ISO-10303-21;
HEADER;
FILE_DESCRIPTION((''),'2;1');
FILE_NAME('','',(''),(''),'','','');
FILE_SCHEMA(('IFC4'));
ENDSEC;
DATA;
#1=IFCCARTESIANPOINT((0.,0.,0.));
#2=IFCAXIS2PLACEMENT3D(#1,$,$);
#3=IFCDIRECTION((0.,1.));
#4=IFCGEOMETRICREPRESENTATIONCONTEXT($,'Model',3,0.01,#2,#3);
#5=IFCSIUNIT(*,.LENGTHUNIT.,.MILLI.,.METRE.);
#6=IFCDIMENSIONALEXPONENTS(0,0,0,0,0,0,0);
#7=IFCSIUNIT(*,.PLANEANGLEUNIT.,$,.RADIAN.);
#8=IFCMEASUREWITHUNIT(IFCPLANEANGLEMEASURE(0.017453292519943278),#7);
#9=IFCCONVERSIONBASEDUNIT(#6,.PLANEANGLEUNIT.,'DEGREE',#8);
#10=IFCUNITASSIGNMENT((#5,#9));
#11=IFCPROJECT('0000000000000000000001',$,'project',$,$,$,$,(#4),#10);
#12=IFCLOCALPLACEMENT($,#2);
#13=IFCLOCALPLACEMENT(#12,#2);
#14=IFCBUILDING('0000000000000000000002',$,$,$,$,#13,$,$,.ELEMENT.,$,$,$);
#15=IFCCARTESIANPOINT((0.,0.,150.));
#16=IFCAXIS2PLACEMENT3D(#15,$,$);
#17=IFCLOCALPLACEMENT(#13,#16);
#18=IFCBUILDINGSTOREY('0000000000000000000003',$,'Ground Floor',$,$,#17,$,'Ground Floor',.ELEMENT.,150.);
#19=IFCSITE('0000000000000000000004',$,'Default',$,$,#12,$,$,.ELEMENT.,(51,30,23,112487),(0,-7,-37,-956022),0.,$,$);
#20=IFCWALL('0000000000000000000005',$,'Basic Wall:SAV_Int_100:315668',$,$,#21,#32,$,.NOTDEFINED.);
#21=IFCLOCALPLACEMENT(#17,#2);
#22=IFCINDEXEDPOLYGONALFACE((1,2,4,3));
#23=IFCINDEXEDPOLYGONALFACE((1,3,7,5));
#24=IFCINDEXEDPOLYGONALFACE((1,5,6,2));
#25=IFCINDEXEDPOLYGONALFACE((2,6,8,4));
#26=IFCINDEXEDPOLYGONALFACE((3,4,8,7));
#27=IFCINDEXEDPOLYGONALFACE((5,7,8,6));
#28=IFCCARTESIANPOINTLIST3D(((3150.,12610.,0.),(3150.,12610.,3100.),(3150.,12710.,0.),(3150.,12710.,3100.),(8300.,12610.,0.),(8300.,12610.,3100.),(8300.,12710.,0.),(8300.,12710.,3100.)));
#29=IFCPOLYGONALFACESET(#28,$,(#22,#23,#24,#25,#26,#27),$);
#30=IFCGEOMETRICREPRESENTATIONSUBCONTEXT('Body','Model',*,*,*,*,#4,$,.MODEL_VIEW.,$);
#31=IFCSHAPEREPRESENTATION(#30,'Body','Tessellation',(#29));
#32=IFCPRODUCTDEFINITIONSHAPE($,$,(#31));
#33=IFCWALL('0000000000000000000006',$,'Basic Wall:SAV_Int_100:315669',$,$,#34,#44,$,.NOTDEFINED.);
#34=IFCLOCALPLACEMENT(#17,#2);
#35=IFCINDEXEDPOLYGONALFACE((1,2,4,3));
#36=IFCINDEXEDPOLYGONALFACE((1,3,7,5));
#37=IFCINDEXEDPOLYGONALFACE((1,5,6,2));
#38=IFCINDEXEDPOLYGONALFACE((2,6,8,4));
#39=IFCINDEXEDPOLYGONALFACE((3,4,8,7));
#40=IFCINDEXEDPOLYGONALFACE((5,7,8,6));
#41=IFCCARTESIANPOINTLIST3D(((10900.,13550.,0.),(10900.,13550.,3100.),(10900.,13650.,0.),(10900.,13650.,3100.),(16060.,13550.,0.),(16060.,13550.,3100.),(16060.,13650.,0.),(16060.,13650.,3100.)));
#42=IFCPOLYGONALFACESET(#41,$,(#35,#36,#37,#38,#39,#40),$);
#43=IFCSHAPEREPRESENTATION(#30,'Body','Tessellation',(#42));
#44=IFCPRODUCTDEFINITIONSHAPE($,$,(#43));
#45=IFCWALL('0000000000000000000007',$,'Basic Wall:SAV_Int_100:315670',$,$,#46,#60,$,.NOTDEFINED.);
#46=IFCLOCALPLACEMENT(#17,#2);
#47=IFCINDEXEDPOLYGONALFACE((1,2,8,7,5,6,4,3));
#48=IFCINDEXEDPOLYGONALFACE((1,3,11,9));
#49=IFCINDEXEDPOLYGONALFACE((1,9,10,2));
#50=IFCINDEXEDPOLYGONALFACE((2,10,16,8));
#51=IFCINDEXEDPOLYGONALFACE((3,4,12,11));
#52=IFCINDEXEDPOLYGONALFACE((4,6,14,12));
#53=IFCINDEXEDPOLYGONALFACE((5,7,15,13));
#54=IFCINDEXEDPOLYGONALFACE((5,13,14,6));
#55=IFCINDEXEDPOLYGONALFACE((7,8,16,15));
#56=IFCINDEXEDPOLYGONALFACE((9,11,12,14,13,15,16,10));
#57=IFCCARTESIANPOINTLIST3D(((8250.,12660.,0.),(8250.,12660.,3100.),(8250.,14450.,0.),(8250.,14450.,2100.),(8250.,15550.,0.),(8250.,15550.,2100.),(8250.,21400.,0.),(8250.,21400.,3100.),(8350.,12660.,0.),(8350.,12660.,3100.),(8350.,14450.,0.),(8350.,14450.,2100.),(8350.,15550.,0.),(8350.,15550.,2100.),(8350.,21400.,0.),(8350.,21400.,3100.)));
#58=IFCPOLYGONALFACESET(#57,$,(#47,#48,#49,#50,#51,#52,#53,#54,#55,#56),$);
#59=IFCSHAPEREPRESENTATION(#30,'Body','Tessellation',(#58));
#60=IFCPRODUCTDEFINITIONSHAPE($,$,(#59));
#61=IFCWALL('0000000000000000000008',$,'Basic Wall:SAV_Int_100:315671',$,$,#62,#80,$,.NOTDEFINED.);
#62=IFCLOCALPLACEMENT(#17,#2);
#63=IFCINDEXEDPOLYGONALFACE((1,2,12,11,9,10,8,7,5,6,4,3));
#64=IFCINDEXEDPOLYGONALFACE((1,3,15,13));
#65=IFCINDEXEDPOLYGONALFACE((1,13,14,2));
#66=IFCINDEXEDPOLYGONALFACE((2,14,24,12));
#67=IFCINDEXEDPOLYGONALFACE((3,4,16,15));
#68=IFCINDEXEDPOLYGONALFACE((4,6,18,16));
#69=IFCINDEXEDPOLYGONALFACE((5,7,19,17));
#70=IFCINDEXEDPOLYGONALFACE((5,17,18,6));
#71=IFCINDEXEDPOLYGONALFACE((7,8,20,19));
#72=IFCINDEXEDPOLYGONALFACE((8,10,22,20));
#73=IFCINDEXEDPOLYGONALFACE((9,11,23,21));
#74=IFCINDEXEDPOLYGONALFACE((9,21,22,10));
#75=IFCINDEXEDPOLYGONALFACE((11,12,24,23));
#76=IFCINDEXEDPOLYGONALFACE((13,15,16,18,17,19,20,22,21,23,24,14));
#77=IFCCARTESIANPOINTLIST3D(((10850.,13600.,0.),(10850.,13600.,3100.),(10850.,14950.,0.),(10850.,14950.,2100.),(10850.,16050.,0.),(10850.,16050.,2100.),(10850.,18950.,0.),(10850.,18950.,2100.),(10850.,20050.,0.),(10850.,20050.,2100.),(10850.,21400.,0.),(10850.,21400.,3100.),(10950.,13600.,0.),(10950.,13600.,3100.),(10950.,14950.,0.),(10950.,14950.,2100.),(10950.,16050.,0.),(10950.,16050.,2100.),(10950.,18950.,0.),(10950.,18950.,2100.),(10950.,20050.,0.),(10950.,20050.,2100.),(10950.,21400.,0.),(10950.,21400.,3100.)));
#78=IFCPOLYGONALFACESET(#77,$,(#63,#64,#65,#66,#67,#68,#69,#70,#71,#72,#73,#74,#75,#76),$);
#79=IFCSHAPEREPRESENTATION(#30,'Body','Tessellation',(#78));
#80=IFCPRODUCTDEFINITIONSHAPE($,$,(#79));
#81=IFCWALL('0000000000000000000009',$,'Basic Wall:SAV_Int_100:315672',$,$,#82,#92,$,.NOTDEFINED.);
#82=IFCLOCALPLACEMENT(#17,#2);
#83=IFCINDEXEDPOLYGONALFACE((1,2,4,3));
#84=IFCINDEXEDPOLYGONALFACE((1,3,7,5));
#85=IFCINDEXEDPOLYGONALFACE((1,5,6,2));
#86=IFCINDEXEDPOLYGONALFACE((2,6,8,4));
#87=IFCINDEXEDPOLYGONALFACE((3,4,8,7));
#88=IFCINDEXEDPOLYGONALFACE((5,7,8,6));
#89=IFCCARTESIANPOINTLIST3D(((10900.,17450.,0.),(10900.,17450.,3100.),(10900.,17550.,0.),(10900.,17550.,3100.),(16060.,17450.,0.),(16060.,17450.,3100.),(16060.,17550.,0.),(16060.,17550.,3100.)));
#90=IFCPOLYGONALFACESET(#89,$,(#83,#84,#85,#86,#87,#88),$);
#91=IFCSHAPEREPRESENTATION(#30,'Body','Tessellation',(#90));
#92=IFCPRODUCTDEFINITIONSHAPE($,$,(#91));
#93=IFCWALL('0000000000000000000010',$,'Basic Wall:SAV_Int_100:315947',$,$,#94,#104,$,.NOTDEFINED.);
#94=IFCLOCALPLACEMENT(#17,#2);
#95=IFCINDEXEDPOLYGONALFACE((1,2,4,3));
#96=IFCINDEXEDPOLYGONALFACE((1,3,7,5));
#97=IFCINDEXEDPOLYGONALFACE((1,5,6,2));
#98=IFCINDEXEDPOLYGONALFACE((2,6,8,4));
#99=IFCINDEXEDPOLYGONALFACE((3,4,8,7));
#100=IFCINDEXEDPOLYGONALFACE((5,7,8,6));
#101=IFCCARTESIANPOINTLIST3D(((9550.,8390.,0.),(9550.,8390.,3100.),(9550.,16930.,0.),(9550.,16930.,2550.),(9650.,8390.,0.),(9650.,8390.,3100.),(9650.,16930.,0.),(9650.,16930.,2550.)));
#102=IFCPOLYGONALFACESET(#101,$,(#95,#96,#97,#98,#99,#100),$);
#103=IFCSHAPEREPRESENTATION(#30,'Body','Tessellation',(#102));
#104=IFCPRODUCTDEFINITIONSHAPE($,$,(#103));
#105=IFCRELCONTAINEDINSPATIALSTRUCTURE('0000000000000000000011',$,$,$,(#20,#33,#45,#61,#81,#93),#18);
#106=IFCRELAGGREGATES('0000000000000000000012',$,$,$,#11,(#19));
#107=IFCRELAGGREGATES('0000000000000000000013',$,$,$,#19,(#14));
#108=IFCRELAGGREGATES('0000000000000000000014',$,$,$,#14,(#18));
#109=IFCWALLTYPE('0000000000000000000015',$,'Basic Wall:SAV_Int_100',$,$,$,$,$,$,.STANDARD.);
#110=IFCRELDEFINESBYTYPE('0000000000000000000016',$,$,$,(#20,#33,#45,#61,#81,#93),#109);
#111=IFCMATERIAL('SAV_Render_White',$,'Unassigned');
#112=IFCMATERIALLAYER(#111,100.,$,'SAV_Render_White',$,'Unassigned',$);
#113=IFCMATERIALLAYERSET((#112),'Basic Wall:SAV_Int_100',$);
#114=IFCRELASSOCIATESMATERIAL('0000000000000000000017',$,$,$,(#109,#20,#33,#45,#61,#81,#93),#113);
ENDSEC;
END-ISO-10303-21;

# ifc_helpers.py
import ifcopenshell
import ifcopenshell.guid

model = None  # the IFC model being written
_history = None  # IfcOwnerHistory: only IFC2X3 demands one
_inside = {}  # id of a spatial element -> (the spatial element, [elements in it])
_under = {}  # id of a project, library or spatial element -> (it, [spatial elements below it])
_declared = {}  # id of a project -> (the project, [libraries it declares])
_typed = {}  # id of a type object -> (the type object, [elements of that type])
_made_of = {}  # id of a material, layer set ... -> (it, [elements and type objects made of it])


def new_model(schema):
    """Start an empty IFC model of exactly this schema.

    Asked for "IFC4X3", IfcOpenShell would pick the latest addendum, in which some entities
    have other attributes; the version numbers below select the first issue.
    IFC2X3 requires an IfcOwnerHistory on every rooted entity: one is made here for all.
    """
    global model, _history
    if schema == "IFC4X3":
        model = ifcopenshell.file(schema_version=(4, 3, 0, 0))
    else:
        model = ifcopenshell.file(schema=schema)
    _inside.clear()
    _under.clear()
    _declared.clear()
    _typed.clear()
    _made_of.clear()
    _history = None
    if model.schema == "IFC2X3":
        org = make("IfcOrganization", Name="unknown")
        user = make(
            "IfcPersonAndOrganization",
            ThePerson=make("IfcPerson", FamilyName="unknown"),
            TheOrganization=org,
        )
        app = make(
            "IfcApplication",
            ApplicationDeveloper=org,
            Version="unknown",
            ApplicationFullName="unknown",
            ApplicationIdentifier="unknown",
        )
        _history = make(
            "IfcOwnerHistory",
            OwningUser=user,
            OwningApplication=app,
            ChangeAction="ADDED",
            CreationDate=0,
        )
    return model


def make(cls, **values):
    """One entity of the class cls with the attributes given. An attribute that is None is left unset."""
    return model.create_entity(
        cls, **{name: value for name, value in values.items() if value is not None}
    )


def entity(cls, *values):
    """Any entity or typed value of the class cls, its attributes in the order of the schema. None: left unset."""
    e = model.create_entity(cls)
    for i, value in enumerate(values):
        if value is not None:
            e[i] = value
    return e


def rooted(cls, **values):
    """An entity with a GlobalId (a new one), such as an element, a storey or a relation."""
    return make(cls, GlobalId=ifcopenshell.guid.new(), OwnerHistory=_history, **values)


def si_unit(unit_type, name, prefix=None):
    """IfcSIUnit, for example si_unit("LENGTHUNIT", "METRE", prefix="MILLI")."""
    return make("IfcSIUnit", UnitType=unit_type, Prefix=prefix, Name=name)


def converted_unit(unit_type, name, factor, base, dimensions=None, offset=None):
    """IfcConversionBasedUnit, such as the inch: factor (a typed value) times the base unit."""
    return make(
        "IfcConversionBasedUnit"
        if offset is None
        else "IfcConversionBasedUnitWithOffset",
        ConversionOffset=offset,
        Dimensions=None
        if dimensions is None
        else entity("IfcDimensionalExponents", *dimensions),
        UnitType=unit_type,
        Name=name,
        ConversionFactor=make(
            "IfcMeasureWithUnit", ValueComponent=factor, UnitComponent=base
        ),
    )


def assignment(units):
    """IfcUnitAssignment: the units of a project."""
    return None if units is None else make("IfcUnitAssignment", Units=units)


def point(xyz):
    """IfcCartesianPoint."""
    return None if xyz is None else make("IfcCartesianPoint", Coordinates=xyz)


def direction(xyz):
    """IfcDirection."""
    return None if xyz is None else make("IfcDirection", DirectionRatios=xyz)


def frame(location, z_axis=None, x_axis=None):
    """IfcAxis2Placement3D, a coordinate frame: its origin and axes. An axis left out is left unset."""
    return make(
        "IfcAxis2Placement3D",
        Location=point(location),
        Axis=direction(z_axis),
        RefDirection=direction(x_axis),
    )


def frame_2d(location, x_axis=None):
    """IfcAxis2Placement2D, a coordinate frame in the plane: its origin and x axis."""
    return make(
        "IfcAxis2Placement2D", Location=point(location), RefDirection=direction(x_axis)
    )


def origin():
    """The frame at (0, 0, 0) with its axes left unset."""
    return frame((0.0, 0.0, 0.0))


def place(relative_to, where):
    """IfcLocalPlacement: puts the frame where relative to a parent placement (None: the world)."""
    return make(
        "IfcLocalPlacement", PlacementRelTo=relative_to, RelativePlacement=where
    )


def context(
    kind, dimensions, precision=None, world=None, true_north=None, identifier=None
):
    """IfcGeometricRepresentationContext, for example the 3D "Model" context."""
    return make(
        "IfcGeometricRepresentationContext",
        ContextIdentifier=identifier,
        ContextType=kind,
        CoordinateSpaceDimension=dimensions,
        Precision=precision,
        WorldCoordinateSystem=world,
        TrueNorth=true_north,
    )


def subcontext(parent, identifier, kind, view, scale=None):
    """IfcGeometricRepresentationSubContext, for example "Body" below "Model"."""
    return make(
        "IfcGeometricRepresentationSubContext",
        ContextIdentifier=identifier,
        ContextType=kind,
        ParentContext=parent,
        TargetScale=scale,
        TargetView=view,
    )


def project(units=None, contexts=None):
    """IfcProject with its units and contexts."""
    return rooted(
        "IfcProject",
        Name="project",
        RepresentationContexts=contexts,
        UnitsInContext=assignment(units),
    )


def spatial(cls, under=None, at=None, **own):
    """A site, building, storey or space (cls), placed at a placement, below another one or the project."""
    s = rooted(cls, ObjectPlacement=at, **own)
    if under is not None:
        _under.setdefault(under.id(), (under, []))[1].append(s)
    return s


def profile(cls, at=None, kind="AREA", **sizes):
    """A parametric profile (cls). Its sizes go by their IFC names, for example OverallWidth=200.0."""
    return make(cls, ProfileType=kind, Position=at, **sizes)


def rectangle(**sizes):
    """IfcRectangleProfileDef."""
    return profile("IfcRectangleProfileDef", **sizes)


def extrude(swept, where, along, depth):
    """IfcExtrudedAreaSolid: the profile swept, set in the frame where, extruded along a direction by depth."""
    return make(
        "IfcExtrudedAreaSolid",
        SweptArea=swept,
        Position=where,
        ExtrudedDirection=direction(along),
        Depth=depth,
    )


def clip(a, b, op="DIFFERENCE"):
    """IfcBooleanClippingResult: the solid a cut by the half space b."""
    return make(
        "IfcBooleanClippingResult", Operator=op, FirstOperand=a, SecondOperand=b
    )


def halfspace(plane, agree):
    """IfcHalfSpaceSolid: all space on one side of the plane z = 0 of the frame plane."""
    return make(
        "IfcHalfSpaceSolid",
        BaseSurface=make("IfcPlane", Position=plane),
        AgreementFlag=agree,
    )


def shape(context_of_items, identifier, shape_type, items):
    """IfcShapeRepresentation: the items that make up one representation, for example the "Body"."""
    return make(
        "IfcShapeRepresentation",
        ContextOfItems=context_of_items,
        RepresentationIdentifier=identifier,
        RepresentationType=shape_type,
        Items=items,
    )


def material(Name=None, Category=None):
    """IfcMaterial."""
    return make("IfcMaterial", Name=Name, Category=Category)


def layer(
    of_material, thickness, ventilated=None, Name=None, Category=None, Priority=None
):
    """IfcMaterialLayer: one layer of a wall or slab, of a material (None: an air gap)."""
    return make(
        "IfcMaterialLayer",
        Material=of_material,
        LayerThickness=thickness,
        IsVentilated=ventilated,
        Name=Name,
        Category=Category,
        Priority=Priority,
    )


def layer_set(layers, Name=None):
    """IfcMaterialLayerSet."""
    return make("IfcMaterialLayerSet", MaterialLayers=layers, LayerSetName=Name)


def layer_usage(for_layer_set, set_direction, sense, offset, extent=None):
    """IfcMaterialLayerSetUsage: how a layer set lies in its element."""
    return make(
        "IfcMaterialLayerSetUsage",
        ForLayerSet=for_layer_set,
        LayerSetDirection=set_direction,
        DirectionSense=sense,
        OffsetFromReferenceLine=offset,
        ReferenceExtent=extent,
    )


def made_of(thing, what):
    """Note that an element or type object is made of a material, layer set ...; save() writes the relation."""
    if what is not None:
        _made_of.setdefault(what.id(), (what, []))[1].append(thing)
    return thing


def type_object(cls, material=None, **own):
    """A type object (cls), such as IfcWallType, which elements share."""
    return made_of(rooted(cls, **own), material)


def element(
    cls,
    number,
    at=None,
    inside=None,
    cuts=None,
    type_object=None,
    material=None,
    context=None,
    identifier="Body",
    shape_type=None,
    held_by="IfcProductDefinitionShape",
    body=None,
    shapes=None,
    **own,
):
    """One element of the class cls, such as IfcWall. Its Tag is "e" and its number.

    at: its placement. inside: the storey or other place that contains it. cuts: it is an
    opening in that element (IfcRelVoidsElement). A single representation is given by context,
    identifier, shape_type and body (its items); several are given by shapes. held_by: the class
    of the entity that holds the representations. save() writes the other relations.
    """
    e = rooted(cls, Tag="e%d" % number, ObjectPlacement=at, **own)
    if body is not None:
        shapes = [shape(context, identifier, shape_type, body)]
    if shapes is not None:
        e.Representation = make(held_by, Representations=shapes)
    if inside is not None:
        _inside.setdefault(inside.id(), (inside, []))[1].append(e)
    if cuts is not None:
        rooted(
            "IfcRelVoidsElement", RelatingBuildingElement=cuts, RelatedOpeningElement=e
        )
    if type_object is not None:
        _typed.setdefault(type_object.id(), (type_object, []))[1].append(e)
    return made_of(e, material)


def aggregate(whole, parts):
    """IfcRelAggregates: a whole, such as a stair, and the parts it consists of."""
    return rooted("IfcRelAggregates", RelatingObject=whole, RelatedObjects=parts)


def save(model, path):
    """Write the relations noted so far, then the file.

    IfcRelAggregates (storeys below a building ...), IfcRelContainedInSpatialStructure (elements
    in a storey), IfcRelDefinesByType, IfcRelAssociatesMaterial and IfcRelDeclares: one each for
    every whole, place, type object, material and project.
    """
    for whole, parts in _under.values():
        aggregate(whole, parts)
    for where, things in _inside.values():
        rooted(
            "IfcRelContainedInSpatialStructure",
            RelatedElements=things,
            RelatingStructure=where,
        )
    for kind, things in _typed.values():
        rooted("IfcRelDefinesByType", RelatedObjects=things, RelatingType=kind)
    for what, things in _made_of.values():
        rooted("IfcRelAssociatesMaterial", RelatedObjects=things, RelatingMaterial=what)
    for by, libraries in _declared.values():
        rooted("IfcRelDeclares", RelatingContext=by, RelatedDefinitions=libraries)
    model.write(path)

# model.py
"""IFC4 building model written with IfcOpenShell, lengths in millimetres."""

from ifc_helpers import new_model, entity, si_unit, converted_unit, direction, frame, frame_2d, origin, place, context, subcontext, project, spatial, rectangle, extrude, clip, halfspace, material, layer, layer_set, layer_usage, type_object, element, save


model = new_model("IFC4")

# Units and contexts
model_context = context("Model", 3, precision=0.01, world=origin(), true_north=direction((0.0, 1.0)))
body_context = subcontext(model_context, "Body", "Model", "MODEL_VIEW")
ifc_project = project(units=[si_unit("LENGTHUNIT", "METRE", prefix="MILLI"), converted_unit("PLANEANGLEUNIT", "DEGREE", entity("IfcPlaneAngleMeasure", 0.017453292519943278), si_unit("PLANEANGLEUNIT", "RADIAN"), dimensions=[0, 0, 0, 0, 0, 0, 0])], contexts=[model_context])

# Site, building, storey
site_placement = place(None, origin())
site = spatial("IfcSite", under=ifc_project, at=site_placement, Name="Default", CompositionType="ELEMENT", RefLatitude=(51, 30, 23, 112487), RefLongitude=(0, -7, -37, -956022), RefElevation=0.0)
building_placement = place(site_placement, origin())
building = spatial("IfcBuilding", under=site, at=building_placement, CompositionType="ELEMENT")
storey_placement = place(building_placement, frame((0.0, 0.0, 150.0)))
storey = spatial("IfcBuildingStorey", under=building, at=storey_placement, Name="Ground Floor", LongName="Ground Floor", CompositionType="ELEMENT", Elevation=150.0)

# Walls
ifc_material_1 = material(Name="SAV_Render_White", Category="Unassigned")
ifc_layer = layer(ifc_material_1, 100.0, Name="SAV_Render_White", Category="Unassigned")
ifc_layer_set = layer_set([ifc_layer], Name="Basic Wall:SAV_Int_100")
ifc_layer_usage_1 = layer_usage(ifc_layer_set, "AXIS2", "NEGATIVE", 50.0)
wall_type = type_object("IfcWallType", Name="Basic Wall:SAV_Int_100", PredefinedType="STANDARD", material=ifc_layer_set)
wall_1_placement = place(storey_placement, frame((3150.0, 12660.0, 0.0)))
element("IfcWall", 1, at=wall_1_placement, inside=storey, type_object=wall_type, material=ifc_layer_usage_1, Name="Basic Wall:SAV_Int_100:315668", PredefinedType="NOTDEFINED", context=body_context, shape_type="SweptSolid", body=[
    extrude(rectangle(XDim=5150.0, YDim=100.0, at=frame_2d((2575.0, 0.0), x_axis=(-1.0, 0.0))), origin(), (0.0, 0.0, 1.0), 3100.0),
])
ifc_layer_usage_2 = layer_usage(ifc_layer_set, "AXIS2", "NEGATIVE", 50.0)
wall_2_placement = place(storey_placement, frame((10900.0, 13600.0, 0.0)))
element("IfcWall", 2, at=wall_2_placement, inside=storey, type_object=wall_type, material=ifc_layer_usage_2, Name="Basic Wall:SAV_Int_100:315669", PredefinedType="NOTDEFINED", context=body_context, shape_type="SweptSolid", body=[
    extrude(rectangle(XDim=5160.0, YDim=100.0, at=frame_2d((2580.0, 0.0), x_axis=(-1.0, 0.0))), origin(), (0.0, 0.0, 1.0), 3100.0),
])

# Wall, opening
ifc_layer_usage_3 = layer_usage(ifc_layer_set, "AXIS2", "NEGATIVE", 50.0)
wall_3_placement = place(storey_placement, frame((8300.0, 12660.0, 0.0), z_axis=(0.0, 0.0, 1.0), x_axis=(0.0, 1.0, 0.0)))
wall_3 = element("IfcWall", 3, at=wall_3_placement, inside=storey, type_object=wall_type, material=ifc_layer_usage_3, Name="Basic Wall:SAV_Int_100:315670", PredefinedType="NOTDEFINED", context=body_context, shape_type="SweptSolid", body=[
    extrude(rectangle(XDim=8740.0, YDim=100.0, at=frame_2d((4370.0, 0.0), x_axis=(1.0, 0.0))), origin(), (0.0, 0.0, 1.0), 3100.0),
])
opening_1_placement = place(wall_3_placement, frame((1790.0, -50.0, 0.0)))
element("IfcOpeningElement", 4, at=opening_1_placement, cuts=wall_3, PredefinedType="OPENING", context=body_context, shape_type="SweptSolid", body=[
    extrude(rectangle(XDim=2100.0, YDim=1100.0, at=frame_2d((1050.0, 550.0), x_axis=(1.0, 0.0))), frame((0.0, 0.0, 0.0), z_axis=(0.0, 1.0, 0.0), x_axis=(0.0, 0.0, 1.0)), (0.0, 0.0, 1.0), 100.0),
])

# Wall, openings
ifc_layer_usage_4 = layer_usage(ifc_layer_set, "AXIS2", "NEGATIVE", 50.0)
wall_4_placement = place(storey_placement, frame((10900.0, 13600.0, 0.0), z_axis=(0.0, 0.0, 1.0), x_axis=(0.0, 1.0, 0.0)))
wall_4 = element("IfcWall", 5, at=wall_4_placement, inside=storey, type_object=wall_type, material=ifc_layer_usage_4, Name="Basic Wall:SAV_Int_100:315671", PredefinedType="NOTDEFINED", context=body_context, shape_type="SweptSolid", body=[
    extrude(rectangle(XDim=7800.0, YDim=100.0, at=frame_2d((3900.0, 0.0), x_axis=(1.0, 0.0))), origin(), (0.0, 0.0, 1.0), 3100.0),
])
opening_2_placement = place(wall_4_placement, frame((5350.0, -50.0, 0.0)))
element("IfcOpeningElement", 6, at=opening_2_placement, cuts=wall_4, PredefinedType="OPENING", context=body_context, shape_type="SweptSolid", body=[
    extrude(rectangle(XDim=2100.0, YDim=1100.0, at=frame_2d((1050.0, 550.0), x_axis=(1.0, 0.0))), frame((0.0, 0.0, 0.0), z_axis=(0.0, 1.0, 0.0), x_axis=(0.0, 0.0, 1.0)), (0.0, 0.0, 1.0), 100.0),
])
opening_3_placement = place(wall_4_placement, frame((1350.0, -50.0, 0.0)))
element("IfcOpeningElement", 7, at=opening_3_placement, cuts=wall_4, PredefinedType="OPENING", context=body_context, shape_type="SweptSolid", body=[
    extrude(rectangle(XDim=2100.0, YDim=1100.0, at=frame_2d((1050.0, 550.0), x_axis=(1.0, 0.0))), frame((0.0, 0.0, 0.0), z_axis=(0.0, 1.0, 0.0), x_axis=(0.0, 0.0, 1.0)), (0.0, 0.0, 1.0), 100.0),
])

# Walls
ifc_layer_usage_5 = layer_usage(ifc_layer_set, "AXIS2", "NEGATIVE", 50.0)
wall_5_placement = place(storey_placement, frame((10900.0, 17500.0, 0.0)))
element("IfcWall", 8, at=wall_5_placement, inside=storey, type_object=wall_type, material=ifc_layer_usage_5, Name="Basic Wall:SAV_Int_100:315672", PredefinedType="NOTDEFINED", context=body_context, shape_type="SweptSolid", body=[
    extrude(rectangle(XDim=5160.0, YDim=100.0, at=frame_2d((2580.0, 0.0), x_axis=(-1.0, 0.0))), origin(), (0.0, 0.0, 1.0), 3100.0),
])
ifc_layer_usage_6 = layer_usage(ifc_layer_set, "AXIS2", "POSITIVE", -50.0)
wall_6_placement = place(storey_placement, frame((9600.0, 8390.0, 0.0), z_axis=(0.0, 0.0, 1.0), x_axis=(0.0, 1.0, 0.0)))
element("IfcWall", 9, at=wall_6_placement, inside=storey, type_object=wall_type, material=ifc_layer_usage_6, Name="Basic Wall:SAV_Int_100:315947", PredefinedType="NOTDEFINED", context=body_context, shape_type="Clipping", body=[
    clip(extrude(rectangle(XDim=8540.0, YDim=100.0, at=frame_2d((4270.0, 0.0), x_axis=(-1.0, 0.0))), origin(), (0.0, 0.0, 1.0), 3100.0), halfspace(frame((0.0, -50.0, 3100.0), z_axis=(0.06427, 0.0, 0.997933), x_axis=(0.0, 1.0, 0.0)), False)),
])

save(model, "model.ifc")
